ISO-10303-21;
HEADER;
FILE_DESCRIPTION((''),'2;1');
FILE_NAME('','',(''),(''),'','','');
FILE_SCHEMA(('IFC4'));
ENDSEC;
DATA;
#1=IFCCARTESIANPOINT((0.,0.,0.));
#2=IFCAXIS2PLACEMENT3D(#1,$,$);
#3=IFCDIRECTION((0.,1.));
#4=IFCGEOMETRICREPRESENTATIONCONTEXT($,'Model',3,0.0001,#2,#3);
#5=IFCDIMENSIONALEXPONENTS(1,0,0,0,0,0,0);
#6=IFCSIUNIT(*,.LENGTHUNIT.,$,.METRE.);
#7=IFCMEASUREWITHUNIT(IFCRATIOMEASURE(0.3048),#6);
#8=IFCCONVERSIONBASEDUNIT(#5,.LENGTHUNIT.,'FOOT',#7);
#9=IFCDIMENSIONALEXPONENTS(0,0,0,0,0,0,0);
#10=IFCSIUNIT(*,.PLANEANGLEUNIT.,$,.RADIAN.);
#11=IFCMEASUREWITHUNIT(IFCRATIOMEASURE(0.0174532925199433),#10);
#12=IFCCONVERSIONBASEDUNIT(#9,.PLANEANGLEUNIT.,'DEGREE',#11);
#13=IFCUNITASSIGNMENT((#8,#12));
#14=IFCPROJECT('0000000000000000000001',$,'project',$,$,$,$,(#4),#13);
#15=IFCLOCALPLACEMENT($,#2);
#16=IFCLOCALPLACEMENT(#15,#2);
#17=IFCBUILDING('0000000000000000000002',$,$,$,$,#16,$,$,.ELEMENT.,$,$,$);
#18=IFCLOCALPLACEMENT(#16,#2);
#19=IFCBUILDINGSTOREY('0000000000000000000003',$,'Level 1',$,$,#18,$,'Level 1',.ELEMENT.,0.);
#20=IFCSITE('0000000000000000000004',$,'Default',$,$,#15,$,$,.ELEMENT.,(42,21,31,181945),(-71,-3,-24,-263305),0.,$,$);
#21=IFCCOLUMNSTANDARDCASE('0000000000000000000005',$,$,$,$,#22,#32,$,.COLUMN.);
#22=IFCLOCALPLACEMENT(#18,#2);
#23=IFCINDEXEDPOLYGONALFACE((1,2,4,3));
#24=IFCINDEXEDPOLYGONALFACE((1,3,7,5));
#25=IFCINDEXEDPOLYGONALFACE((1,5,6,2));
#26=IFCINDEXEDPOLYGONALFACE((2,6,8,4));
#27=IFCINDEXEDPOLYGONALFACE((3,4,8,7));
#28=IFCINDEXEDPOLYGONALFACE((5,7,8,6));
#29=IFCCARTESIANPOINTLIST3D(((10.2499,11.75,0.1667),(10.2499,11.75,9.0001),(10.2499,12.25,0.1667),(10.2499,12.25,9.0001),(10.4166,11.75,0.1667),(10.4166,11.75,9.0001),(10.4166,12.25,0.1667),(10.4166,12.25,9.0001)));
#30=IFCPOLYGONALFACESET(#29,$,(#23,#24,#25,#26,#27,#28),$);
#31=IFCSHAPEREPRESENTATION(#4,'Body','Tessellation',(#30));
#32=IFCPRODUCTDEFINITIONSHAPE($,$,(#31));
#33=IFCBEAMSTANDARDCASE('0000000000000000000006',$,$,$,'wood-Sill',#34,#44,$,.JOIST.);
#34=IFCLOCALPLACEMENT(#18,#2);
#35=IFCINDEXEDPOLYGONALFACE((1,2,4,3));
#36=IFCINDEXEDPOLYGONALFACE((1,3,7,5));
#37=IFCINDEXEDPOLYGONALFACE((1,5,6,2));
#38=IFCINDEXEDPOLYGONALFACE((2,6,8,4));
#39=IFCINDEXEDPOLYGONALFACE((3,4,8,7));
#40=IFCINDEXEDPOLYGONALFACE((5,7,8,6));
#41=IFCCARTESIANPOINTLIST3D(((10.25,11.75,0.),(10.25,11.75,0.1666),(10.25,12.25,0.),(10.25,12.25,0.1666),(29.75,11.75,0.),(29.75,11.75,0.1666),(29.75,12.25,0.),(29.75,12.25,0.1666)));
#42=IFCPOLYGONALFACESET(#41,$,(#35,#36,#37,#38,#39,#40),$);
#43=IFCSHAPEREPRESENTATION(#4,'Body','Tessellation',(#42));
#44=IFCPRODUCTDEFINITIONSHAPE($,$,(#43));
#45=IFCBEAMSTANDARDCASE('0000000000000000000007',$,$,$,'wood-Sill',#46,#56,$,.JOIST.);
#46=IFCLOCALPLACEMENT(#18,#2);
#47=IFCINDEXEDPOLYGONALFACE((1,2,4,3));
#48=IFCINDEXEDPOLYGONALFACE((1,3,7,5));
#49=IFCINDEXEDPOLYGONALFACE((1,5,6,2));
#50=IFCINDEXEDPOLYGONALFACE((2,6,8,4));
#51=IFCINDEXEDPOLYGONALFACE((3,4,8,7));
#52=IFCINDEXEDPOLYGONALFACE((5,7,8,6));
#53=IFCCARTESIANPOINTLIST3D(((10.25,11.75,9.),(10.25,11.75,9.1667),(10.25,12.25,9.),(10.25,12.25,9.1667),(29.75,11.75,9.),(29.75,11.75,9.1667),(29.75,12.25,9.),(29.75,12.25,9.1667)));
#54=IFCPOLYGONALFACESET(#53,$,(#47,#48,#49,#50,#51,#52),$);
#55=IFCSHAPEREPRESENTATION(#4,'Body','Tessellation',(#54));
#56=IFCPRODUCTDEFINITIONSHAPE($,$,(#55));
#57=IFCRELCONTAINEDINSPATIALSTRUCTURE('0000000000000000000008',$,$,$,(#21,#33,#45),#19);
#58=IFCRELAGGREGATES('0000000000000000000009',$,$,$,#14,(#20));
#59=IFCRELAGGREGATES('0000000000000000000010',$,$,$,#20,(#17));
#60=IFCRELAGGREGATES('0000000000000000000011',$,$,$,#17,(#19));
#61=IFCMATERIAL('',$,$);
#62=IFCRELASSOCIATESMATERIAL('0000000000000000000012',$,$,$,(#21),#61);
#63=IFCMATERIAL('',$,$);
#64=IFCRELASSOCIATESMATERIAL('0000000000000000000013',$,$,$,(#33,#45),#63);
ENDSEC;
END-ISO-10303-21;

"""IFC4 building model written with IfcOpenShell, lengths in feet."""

from ifc_helpers import new_model, entity, si_unit, converted_unit, direction, frame, origin, origin_with_axes, place, context, project, spatial, rectangle, extrude, material, element, save


model = new_model("IFC4")

# Units and contexts
model_context = context("Model", 3, precision=0.0001, world=origin(), true_north=direction((0.0, 1.0)))
ifc_project = project(units=[converted_unit("LENGTHUNIT", "FOOT", entity("IfcRatioMeasure", 0.3048), si_unit("LENGTHUNIT", "METRE"), dimensions=[1, 0, 0, 0, 0, 0, 0]), converted_unit("PLANEANGLEUNIT", "DEGREE", entity("IfcRatioMeasure", 0.0174532925199433), si_unit("PLANEANGLEUNIT", "RADIAN"), dimensions=[0, 0, 0, 0, 0, 0, 0])], contexts=[model_context])

# Site, building, storey
site_placement = place(None, origin())
site = spatial("IfcSite", under=ifc_project, at=site_placement, Name="Default", CompositionType="ELEMENT", RefLatitude=(42, 21, 31, 181945), RefLongitude=(-71, -3, -24, -263305), RefElevation=0.0)
building_placement = place(site_placement, origin())
building = spatial("IfcBuilding", under=site, at=building_placement, CompositionType="ELEMENT")
storey_placement = place(building_placement, origin())
storey = spatial("IfcBuildingStorey", under=building, at=storey_placement, Name="Level 1", LongName="Level 1", CompositionType="ELEMENT", Elevation=0.0)

# Column
ifc_material_1 = material(Name="")
placement_1 = place(storey_placement, frame((10.25, 12.0, 0.0)))
for number, where, z_axis, x_axis in (
    (1, (0.0833, 0.0, 0.1667), (0.0, 0.0, 1.0), (1.0, 0.0, 0.0)),
):
    element("IfcColumnStandardCase", number, at=place(placement_1, frame(where, z_axis=z_axis, x_axis=x_axis)), inside=storey, material=ifc_material_1, PredefinedType="COLUMN", context=model_context, shape_type="SweptSolid", body=[
        extrude(rectangle(XDim=0.1667, YDim=0.5), origin(), (0.0, 0.0, 1.0), 8.8334),
    ])

# Beams
ifc_material_2 = material(Name="")
for number, where, z_axis, x_axis in (
    (2, (0.0, 0.0, 0.0833), (1.0, 0.0, 0.0), (0.0, 0.0, 1.0)),
    (3, (0.0, 0.0, 9.0834), (1.0, 0.0, 0.0), (0.0, 0.0, 1.0)),
):
    element("IfcBeamStandardCase", number, at=place(placement_1, frame(where, z_axis=z_axis, x_axis=x_axis)), inside=storey, material=ifc_material_2, ObjectType="wood-Sill", PredefinedType="JOIST", context=model_context, shape_type="SweptSolid", body=[
        extrude(rectangle(XDim=0.1667, YDim=0.5), origin_with_axes(), (0.0, 0.0, 1.0), 19.5),
    ])

save(model, "model.ifc")
